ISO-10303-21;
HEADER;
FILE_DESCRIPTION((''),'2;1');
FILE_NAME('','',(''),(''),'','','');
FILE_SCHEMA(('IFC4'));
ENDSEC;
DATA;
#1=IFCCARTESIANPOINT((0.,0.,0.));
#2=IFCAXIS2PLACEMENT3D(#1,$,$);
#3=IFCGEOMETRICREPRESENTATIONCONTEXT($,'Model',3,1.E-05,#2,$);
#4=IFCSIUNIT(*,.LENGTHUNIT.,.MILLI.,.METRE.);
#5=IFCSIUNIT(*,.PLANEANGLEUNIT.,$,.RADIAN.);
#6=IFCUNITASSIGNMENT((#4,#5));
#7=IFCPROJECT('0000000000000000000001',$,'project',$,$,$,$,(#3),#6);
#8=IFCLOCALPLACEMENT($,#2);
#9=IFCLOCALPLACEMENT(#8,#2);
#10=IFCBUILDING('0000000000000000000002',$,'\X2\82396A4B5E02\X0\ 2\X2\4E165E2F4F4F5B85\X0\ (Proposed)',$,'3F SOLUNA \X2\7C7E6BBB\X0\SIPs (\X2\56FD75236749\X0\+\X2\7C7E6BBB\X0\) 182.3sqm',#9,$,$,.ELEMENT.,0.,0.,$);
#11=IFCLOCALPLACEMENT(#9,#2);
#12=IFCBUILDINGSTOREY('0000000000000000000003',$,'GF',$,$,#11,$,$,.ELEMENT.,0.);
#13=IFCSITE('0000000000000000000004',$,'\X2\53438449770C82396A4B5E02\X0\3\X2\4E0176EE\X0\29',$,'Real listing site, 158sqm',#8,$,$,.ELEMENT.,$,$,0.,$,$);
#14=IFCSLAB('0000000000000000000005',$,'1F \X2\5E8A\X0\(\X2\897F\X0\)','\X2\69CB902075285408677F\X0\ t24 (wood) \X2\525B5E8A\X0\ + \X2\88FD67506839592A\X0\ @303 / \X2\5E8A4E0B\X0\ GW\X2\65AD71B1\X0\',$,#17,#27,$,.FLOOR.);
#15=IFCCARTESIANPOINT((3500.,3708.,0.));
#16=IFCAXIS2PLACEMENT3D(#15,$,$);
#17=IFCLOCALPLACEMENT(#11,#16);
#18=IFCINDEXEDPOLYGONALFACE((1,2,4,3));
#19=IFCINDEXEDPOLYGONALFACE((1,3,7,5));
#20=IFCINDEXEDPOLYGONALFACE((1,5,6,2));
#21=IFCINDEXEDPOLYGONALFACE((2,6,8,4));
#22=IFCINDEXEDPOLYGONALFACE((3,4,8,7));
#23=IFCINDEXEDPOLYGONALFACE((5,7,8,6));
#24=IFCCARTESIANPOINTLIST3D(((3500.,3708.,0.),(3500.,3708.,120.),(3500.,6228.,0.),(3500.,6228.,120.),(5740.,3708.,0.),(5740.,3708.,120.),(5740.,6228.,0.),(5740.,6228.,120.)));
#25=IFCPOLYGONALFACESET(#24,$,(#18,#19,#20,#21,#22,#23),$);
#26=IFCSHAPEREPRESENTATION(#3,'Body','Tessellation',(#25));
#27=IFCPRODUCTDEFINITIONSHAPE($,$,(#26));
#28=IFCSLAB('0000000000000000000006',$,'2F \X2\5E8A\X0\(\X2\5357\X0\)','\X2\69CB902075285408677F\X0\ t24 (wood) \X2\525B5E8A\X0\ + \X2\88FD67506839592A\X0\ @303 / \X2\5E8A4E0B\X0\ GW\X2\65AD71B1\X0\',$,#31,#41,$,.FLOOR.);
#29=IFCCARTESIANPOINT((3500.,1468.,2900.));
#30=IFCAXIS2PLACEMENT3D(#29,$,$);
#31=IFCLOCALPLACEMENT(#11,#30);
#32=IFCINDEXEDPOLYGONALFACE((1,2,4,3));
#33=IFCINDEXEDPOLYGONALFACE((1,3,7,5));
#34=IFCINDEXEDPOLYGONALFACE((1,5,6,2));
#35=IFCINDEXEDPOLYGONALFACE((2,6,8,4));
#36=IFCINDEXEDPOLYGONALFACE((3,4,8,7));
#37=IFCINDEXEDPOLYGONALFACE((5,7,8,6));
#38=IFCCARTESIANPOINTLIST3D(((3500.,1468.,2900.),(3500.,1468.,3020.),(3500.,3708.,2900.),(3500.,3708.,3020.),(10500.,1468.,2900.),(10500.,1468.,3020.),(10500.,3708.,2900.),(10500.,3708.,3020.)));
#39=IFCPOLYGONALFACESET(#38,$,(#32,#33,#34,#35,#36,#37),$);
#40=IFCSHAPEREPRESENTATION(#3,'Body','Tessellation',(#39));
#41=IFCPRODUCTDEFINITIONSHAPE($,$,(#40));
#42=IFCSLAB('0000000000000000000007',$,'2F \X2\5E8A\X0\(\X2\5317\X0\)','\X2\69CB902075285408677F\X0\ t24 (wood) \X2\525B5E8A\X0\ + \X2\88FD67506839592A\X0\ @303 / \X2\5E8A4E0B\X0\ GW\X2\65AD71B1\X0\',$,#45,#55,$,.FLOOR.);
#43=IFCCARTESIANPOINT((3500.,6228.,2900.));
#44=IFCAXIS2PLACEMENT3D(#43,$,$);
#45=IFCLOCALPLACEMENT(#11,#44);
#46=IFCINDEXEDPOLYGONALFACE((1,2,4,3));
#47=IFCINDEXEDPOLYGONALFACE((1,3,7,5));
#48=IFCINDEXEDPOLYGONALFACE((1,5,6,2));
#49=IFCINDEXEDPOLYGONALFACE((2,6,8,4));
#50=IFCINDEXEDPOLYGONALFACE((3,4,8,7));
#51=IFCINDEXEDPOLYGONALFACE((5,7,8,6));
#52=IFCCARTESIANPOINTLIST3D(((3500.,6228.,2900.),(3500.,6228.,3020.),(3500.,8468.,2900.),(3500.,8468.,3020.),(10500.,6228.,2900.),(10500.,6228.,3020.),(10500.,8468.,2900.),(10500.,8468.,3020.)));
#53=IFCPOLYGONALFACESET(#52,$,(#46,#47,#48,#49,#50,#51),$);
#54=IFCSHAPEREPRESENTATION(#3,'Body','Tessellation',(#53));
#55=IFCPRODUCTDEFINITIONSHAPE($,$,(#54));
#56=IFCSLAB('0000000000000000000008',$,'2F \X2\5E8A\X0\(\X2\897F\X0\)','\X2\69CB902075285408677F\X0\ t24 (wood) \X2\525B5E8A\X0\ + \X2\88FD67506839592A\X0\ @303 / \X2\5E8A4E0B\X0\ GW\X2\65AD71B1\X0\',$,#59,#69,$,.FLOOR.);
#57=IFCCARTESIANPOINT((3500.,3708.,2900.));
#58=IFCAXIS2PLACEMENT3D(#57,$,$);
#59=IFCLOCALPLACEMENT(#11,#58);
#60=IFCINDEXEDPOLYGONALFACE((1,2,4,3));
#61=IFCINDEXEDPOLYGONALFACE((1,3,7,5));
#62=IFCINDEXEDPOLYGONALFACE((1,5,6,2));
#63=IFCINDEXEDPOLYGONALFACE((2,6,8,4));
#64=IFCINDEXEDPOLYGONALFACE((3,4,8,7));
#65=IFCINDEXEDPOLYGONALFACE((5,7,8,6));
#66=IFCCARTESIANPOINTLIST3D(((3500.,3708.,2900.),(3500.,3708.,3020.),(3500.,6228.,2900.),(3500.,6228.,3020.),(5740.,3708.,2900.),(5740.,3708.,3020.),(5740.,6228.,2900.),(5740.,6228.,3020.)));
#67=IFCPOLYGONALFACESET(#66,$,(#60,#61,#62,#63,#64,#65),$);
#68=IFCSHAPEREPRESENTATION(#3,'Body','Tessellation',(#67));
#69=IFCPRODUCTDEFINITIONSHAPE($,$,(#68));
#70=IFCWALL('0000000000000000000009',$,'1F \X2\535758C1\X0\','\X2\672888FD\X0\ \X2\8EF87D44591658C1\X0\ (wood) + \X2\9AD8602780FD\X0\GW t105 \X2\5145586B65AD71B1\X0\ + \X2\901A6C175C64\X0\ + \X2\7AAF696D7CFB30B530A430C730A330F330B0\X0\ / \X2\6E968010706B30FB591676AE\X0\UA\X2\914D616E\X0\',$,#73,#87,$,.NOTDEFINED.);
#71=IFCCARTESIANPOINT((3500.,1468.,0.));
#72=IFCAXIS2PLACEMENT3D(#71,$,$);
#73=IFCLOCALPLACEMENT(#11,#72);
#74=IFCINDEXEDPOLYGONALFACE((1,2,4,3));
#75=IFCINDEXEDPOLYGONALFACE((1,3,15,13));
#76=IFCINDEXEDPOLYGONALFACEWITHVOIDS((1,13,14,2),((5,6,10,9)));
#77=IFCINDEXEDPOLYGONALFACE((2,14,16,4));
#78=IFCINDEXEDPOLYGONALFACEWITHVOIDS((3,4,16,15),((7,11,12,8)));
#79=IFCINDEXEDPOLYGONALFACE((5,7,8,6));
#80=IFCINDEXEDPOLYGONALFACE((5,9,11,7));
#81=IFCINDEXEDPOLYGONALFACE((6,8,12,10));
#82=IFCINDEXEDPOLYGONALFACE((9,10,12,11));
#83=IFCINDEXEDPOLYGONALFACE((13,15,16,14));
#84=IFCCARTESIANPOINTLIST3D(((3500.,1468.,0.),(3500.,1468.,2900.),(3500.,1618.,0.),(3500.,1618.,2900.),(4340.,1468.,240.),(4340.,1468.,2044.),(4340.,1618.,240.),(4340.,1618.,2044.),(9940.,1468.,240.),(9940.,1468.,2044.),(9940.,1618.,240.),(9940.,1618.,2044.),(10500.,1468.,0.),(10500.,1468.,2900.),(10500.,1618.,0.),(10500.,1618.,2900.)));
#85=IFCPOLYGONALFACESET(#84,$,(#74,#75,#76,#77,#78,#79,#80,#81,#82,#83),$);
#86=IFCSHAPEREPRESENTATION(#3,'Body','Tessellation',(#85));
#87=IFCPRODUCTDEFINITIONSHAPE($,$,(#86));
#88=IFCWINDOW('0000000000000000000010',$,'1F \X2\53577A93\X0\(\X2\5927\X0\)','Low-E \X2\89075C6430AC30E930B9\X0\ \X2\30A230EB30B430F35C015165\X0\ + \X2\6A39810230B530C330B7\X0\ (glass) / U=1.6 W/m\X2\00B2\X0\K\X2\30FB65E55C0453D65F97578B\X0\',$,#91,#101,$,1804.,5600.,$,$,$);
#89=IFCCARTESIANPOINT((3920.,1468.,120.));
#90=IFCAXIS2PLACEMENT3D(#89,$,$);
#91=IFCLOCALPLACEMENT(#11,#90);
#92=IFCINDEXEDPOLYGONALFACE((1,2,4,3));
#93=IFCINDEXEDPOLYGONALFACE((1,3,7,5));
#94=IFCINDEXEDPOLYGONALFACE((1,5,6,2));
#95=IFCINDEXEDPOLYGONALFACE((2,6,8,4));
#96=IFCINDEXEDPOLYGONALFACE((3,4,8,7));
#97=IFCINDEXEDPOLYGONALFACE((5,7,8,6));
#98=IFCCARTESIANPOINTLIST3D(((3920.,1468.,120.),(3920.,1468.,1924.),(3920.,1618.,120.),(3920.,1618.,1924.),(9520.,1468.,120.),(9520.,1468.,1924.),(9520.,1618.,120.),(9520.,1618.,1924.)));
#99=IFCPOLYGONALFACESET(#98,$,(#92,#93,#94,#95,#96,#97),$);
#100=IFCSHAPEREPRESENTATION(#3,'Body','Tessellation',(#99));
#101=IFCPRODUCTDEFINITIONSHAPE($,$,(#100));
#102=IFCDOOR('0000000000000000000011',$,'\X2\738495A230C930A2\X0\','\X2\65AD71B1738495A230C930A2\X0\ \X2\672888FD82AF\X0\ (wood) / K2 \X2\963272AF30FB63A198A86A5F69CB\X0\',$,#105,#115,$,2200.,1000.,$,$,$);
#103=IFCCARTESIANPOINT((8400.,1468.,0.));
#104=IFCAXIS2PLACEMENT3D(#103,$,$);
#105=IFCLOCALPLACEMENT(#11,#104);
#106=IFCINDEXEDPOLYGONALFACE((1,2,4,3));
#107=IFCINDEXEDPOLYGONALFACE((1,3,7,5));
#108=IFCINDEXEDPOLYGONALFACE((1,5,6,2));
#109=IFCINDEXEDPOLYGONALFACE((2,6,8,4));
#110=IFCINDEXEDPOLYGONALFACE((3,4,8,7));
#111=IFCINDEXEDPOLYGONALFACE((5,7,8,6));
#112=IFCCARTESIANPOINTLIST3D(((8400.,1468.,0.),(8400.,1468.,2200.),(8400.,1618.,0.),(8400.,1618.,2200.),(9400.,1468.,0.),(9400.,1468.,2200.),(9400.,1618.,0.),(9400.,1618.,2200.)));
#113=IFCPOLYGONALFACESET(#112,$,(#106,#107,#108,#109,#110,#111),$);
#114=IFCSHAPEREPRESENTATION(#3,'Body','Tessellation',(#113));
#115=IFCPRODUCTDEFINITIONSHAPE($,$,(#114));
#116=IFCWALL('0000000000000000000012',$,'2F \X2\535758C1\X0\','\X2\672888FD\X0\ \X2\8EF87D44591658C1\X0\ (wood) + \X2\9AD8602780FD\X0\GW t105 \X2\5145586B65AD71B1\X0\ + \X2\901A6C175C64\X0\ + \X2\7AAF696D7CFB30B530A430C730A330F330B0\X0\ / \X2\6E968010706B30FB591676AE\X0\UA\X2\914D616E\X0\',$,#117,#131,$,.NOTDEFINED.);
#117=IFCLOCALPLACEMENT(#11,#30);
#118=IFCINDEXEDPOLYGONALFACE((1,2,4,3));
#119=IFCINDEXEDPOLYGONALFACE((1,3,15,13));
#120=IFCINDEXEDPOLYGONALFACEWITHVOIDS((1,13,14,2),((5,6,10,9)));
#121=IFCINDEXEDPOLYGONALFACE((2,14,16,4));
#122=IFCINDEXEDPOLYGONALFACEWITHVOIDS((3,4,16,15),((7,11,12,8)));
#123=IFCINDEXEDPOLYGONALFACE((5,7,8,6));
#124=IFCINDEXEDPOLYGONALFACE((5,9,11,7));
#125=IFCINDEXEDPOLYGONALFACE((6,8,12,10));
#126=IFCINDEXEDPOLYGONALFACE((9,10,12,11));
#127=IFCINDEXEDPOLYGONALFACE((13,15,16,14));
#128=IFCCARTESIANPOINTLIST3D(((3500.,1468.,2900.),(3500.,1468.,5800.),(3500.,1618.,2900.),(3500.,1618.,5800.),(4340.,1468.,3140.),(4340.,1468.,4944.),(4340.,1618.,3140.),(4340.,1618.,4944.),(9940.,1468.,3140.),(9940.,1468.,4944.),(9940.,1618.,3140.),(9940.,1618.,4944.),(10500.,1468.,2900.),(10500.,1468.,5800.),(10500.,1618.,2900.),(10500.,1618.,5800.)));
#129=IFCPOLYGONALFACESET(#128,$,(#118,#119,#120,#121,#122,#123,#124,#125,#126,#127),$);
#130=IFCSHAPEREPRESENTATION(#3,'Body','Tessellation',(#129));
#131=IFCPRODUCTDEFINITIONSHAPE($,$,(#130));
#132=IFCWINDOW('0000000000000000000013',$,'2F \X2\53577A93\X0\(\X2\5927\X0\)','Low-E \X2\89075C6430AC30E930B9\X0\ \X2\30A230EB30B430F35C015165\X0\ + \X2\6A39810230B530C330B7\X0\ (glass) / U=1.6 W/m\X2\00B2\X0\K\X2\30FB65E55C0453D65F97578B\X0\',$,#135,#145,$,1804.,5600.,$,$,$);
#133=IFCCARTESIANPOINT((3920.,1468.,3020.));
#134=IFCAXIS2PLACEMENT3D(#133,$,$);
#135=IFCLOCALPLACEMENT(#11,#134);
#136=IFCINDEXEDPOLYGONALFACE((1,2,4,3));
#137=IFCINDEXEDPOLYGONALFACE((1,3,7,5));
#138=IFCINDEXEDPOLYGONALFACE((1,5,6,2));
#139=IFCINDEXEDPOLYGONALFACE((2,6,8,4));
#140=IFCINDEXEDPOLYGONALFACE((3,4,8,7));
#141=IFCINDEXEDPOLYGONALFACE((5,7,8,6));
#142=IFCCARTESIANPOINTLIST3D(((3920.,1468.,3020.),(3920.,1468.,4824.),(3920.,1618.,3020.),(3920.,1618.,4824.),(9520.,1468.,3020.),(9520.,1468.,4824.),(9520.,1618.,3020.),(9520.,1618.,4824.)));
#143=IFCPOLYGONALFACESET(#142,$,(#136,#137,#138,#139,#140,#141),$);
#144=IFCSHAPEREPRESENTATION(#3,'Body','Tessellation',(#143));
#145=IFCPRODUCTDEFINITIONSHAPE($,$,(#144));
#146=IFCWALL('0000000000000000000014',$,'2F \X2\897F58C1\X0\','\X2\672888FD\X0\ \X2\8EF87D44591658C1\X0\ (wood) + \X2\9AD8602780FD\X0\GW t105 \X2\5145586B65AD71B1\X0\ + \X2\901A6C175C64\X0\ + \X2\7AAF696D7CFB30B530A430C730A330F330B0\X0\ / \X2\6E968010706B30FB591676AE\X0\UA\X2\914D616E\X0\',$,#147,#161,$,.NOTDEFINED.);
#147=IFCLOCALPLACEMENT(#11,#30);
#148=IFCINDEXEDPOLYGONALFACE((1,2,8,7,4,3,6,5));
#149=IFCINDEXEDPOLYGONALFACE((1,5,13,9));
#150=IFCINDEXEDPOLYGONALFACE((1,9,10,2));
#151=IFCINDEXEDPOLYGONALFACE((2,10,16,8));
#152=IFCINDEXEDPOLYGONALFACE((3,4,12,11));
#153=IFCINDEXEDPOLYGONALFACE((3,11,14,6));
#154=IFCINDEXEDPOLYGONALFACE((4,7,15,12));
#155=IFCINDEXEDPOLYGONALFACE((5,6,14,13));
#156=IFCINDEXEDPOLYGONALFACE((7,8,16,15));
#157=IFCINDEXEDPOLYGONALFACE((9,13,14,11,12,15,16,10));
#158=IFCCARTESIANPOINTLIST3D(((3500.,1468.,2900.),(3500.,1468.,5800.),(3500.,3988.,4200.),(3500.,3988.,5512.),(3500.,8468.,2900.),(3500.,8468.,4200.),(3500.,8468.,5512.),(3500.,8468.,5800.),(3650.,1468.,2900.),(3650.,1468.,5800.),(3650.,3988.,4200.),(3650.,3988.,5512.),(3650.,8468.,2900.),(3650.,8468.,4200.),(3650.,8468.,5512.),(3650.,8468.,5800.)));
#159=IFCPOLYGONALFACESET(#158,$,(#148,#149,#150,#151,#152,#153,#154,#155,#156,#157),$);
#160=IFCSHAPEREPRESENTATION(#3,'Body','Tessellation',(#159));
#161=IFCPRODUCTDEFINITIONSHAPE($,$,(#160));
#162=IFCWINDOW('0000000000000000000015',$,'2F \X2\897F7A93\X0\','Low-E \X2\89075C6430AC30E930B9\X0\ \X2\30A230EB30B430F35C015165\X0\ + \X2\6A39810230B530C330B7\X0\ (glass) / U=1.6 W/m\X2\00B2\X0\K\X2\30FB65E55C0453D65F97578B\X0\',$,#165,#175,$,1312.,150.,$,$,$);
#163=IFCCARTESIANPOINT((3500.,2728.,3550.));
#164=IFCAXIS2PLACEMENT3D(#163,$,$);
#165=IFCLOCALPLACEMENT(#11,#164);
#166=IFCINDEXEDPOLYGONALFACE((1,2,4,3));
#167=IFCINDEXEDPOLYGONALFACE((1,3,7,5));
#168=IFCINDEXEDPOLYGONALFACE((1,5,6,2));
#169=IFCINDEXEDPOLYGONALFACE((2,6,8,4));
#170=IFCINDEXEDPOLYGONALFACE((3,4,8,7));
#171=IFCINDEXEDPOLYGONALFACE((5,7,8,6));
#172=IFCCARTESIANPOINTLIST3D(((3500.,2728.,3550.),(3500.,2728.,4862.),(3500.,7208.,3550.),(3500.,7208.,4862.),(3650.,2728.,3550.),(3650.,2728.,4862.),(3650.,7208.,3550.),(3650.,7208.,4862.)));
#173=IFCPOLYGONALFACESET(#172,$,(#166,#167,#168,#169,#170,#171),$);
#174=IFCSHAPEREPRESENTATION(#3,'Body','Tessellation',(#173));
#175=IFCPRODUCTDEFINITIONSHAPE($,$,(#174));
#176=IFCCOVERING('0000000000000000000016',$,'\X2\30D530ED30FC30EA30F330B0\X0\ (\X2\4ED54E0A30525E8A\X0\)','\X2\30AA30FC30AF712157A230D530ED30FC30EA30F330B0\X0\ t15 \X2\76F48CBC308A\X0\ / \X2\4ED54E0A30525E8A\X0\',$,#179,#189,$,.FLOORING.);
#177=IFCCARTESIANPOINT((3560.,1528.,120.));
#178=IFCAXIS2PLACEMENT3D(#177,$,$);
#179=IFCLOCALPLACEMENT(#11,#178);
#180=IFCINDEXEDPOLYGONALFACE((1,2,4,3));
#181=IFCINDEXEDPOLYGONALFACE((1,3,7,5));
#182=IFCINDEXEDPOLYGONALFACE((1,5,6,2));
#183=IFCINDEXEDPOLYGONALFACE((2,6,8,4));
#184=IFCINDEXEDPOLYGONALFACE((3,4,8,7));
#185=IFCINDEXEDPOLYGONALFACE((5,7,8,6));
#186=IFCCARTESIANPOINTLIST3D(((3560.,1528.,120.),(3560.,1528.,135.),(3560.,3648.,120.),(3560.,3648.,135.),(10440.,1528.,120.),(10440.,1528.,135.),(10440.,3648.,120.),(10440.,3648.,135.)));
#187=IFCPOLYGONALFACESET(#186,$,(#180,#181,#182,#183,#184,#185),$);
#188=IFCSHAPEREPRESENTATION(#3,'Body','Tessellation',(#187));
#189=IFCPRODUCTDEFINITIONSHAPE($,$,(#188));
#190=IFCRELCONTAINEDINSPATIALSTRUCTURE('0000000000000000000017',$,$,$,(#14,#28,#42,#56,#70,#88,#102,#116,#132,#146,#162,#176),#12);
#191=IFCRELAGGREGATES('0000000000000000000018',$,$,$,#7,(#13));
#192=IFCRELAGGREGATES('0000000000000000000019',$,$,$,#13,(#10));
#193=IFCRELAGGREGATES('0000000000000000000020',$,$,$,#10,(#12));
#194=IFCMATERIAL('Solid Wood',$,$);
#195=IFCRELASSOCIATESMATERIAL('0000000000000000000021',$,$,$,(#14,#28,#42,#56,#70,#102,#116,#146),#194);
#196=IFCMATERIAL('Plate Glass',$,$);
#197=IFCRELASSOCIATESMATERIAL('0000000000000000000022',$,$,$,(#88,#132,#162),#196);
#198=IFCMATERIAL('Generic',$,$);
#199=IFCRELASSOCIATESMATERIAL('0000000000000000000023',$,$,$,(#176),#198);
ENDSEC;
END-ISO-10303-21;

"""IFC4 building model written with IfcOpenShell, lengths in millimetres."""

from ifc_helpers import new_model, si_unit, frame, frame_2d, origin, place, context, project, spatial, rectangle, extrude, material, element, fill, save


model = new_model("IFC4")

# Units and contexts
model_context = context("Model", 3, precision=1e-05, world=origin())
ifc_project = project(units=[si_unit("LENGTHUNIT", "METRE", prefix="MILLI"), si_unit("PLANEANGLEUNIT", "RADIAN")], contexts=[model_context])

# Site, building, storey
site_placement = place(None, origin())
site = spatial("IfcSite", under=ifc_project, at=site_placement, Name="千葉県船橋市3丁目29", ObjectType="Real listing site, 158sqm", CompositionType="ELEMENT", RefElevation=0.0)
building_placement = place(site_placement, origin())
building = spatial("IfcBuilding", under=site, at=building_placement, Name="船橋市 2世帯住宅 (Proposed)", ObjectType="3F SOLUNA 籾殻SIPs (国産杉+籾殻) 182.3sqm", CompositionType="ELEMENT", ElevationOfRefHeight=0.0, ElevationOfTerrain=0.0)
storey_placement = place(building_placement, origin())
storey = spatial("IfcBuildingStorey", under=building, at=storey_placement, Name="GF", CompositionType="ELEMENT", Elevation=0.0)

# Slabs
ifc_material_1 = material(Name="Solid Wood")
slab_1_placement = place(storey_placement, frame((3500.0, 3708.0, 0.0)))
element("IfcSlab", 1, at=slab_1_placement, inside=storey, material=ifc_material_1, Name="1F 床(西)", Description="構造用合板 t24 (wood) 剛床 + 製材根太 @303 / 床下 GW断熱", PredefinedType="FLOOR", context=model_context, shape_type="SweptSolid", body=[
    extrude(rectangle(XDim=2240.0, YDim=2520.0, at=frame_2d((1120.0, 1260.0))), frame((3500.0, 3708.0, 0.0)), (0.0, 0.0, 1.0), 120.0),
])
slab_2_placement = place(storey_placement, frame((3500.0, 1468.0, 2900.0)))
element("IfcSlab", 2, at=slab_2_placement, inside=storey, material=ifc_material_1, Name="2F 床(南)", Description="構造用合板 t24 (wood) 剛床 + 製材根太 @303 / 床下 GW断熱", PredefinedType="FLOOR", context=model_context, shape_type="SweptSolid", body=[
    extrude(rectangle(XDim=7000.0, YDim=2240.0, at=frame_2d((3500.0, 1120.0))), frame((3500.0, 1468.0, 2900.0)), (0.0, 0.0, 1.0), 120.0),
])
slab_3_placement = place(storey_placement, frame((3500.0, 6228.0, 2900.0)))
element("IfcSlab", 3, at=slab_3_placement, inside=storey, material=ifc_material_1, Name="2F 床(北)", Description="構造用合板 t24 (wood) 剛床 + 製材根太 @303 / 床下 GW断熱", PredefinedType="FLOOR", context=model_context, shape_type="SweptSolid", body=[
    extrude(rectangle(XDim=7000.0, YDim=2240.0, at=frame_2d((3500.0, 1120.0))), frame((3500.0, 6228.0, 2900.0)), (0.0, 0.0, 1.0), 120.0),
])
slab_4_placement = place(storey_placement, frame((3500.0, 3708.0, 2900.0)))
element("IfcSlab", 4, at=slab_4_placement, inside=storey, material=ifc_material_1, Name="2F 床(西)", Description="構造用合板 t24 (wood) 剛床 + 製材根太 @303 / 床下 GW断熱", PredefinedType="FLOOR", context=model_context, shape_type="SweptSolid", body=[
    extrude(rectangle(XDim=2240.0, YDim=2520.0, at=frame_2d((1120.0, 1260.0))), frame((3500.0, 3708.0, 2900.0)), (0.0, 0.0, 1.0), 120.0),
])

# Wall, openings, window, door
wall_1_placement = place(storey_placement, frame((3500.0, 1468.0, 0.0)))
wall_1 = element("IfcWall", 5, at=wall_1_placement, inside=storey, material=ifc_material_1, Name="1F 南壁", Description="木製 軸組外壁 (wood) + 高性能GW t105 充填断熱 + 通気層 + 窯業系サイディング / 準耐火・外皮UA配慮", PredefinedType="NOTDEFINED", context=model_context, shape_type="SweptSolid", body=[
    extrude(rectangle(XDim=7000.0, YDim=150.0, at=frame_2d((3500.0, 75.0))), frame((3500.0, 1468.0, 0.0)), (0.0, 0.0, 1.0), 2900.0),
])
opening_1_placement = place(storey_placement, frame((3920.0, 1468.0, 120.0)))
opening_1 = element("IfcOpeningElement", 6, at=opening_1_placement, cuts=wall_1, PredefinedType="NOTDEFINED", context=model_context, shape_type="SweptSolid", body=[
    extrude(rectangle(XDim=5600.0, YDim=150.0, at=frame_2d((2800.0, 75.0))), frame((3920.0, 1468.0, 120.0)), (0.0, 0.0, 1.0), 1804.0),
])
opening_2_placement = place(storey_placement, frame((8400.0, 1468.0, 0.0)))
opening_2 = element("IfcOpeningElement", 7, at=opening_2_placement, cuts=wall_1, PredefinedType="NOTDEFINED", context=model_context, shape_type="SweptSolid", body=[
    extrude(rectangle(XDim=1000.0, YDim=150.0, at=frame_2d((500.0, 75.0))), frame((8400.0, 1468.0, 0.0)), (0.0, 0.0, 1.0), 2200.0),
])
ifc_material_2 = material(Name="Plate Glass")
window_1_placement = place(storey_placement, frame((3920.0, 1468.0, 120.0)))
window_1 = element("IfcWindow", 8, at=window_1_placement, inside=storey, material=ifc_material_2, Name="1F 南窓(大)", Description="Low-E 複層ガラス アルゴン封入 + 樹脂サッシ (glass) / U=1.6 W/m²K・日射取得型", OverallHeight=1804.0, OverallWidth=5600.0, context=model_context, shape_type="SweptSolid", body=[
    extrude(rectangle(XDim=5600.0, YDim=150.0, at=frame_2d((2800.0, 75.0))), frame((3920.0, 1468.0, 120.0)), (0.0, 0.0, 1.0), 1804.0),
])
fill(opening_1, window_1)
door_placement = place(storey_placement, frame((8400.0, 1468.0, 0.0)))
door = element("IfcDoor", 9, at=door_placement, inside=storey, material=ifc_material_1, Name="玄関ドア", Description="断熱玄関ドア 木製芯 (wood) / K2 防犯・採風機構", OverallHeight=2200.0, OverallWidth=1000.0, context=model_context, shape_type="SweptSolid", body=[
    extrude(rectangle(XDim=1000.0, YDim=150.0, at=frame_2d((500.0, 75.0))), frame((8400.0, 1468.0, 0.0)), (0.0, 0.0, 1.0), 2200.0),
])
fill(opening_2, door)

# Wall, opening, window
wall_2_placement = place(storey_placement, frame((3500.0, 1468.0, 2900.0)))
wall_2 = element("IfcWall", 10, at=wall_2_placement, inside=storey, material=ifc_material_1, Name="2F 南壁", Description="木製 軸組外壁 (wood) + 高性能GW t105 充填断熱 + 通気層 + 窯業系サイディング / 準耐火・外皮UA配慮", PredefinedType="NOTDEFINED", context=model_context, shape_type="SweptSolid", body=[
    extrude(rectangle(XDim=7000.0, YDim=150.0, at=frame_2d((3500.0, 75.0))), frame((3500.0, 1468.0, 2900.0)), (0.0, 0.0, 1.0), 2900.0),
])
opening_3_placement = place(storey_placement, frame((3920.0, 1468.0, 3020.0)))
opening_3 = element("IfcOpeningElement", 11, at=opening_3_placement, cuts=wall_2, PredefinedType="NOTDEFINED", context=model_context, shape_type="SweptSolid", body=[
    extrude(rectangle(XDim=5600.0, YDim=150.0, at=frame_2d((2800.0, 75.0))), frame((3920.0, 1468.0, 3020.0)), (0.0, 0.0, 1.0), 1804.0),
])
window_2_placement = place(storey_placement, frame((3920.0, 1468.0, 3020.0)))
window_2 = element("IfcWindow", 12, at=window_2_placement, inside=storey, material=ifc_material_2, Name="2F 南窓(大)", Description="Low-E 複層ガラス アルゴン封入 + 樹脂サッシ (glass) / U=1.6 W/m²K・日射取得型", OverallHeight=1804.0, OverallWidth=5600.0, context=model_context, shape_type="SweptSolid", body=[
    extrude(rectangle(XDim=5600.0, YDim=150.0, at=frame_2d((2800.0, 75.0))), frame((3920.0, 1468.0, 3020.0)), (0.0, 0.0, 1.0), 1804.0),
])
fill(opening_3, window_2)

# Wall, opening, window
wall_3_placement = place(storey_placement, frame((3500.0, 1468.0, 2900.0)))
wall_3 = element("IfcWall", 13, at=wall_3_placement, inside=storey, material=ifc_material_1, Name="2F 西壁", Description="木製 軸組外壁 (wood) + 高性能GW t105 充填断熱 + 通気層 + 窯業系サイディング / 準耐火・外皮UA配慮", PredefinedType="NOTDEFINED", context=model_context, shape_type="SweptSolid", body=[
    extrude(rectangle(XDim=150.0, YDim=7000.0, at=frame_2d((75.0, 3500.0))), frame((3500.0, 1468.0, 2900.0)), (0.0, 0.0, 1.0), 2900.0),
])
opening_4_placement = place(storey_placement, frame((3500.0, 2728.0, 3550.0)))
opening_4 = element("IfcOpeningElement", 14, at=opening_4_placement, cuts=wall_3, PredefinedType="NOTDEFINED", context=model_context, shape_type="SweptSolid", body=[
    extrude(rectangle(XDim=150.0, YDim=4480.0, at=frame_2d((75.0, 2240.0))), frame((3500.0, 2728.0, 3550.0)), (0.0, 0.0, 1.0), 1312.0),
])
window_3_placement = place(storey_placement, frame((3500.0, 2728.0, 3550.0)))
window_3 = element("IfcWindow", 15, at=window_3_placement, inside=storey, material=ifc_material_2, Name="2F 西窓", Description="Low-E 複層ガラス アルゴン封入 + 樹脂サッシ (glass) / U=1.6 W/m²K・日射取得型", OverallHeight=1312.0, OverallWidth=150.0, context=model_context, shape_type="SweptSolid", body=[
    extrude(rectangle(XDim=150.0, YDim=4480.0, at=frame_2d((75.0, 2240.0))), frame((3500.0, 2728.0, 3550.0)), (0.0, 0.0, 1.0), 1312.0),
])
fill(opening_4, window_3)

# Covering
ifc_material_3 = material(Name="Generic")
covering_1_placement = place(storey_placement, frame((3560.0, 1528.0, 120.0)))
element("IfcCovering", 16, at=covering_1_placement, inside=storey, material=ifc_material_3, Name="フローリング (仕上げ床)", Description="オーク無垢フローリング t15 直貼り / 仕上げ床", PredefinedType="FLOORING", context=model_context, shape_type="SweptSolid", body=[
    extrude(rectangle(XDim=6880.0, YDim=2120.0, at=frame_2d((3440.0, 1060.0))), frame((3560.0, 1528.0, 120.0)), (0.0, 0.0, 1.0), 15.0),
])

save(model, "model.ifc")
